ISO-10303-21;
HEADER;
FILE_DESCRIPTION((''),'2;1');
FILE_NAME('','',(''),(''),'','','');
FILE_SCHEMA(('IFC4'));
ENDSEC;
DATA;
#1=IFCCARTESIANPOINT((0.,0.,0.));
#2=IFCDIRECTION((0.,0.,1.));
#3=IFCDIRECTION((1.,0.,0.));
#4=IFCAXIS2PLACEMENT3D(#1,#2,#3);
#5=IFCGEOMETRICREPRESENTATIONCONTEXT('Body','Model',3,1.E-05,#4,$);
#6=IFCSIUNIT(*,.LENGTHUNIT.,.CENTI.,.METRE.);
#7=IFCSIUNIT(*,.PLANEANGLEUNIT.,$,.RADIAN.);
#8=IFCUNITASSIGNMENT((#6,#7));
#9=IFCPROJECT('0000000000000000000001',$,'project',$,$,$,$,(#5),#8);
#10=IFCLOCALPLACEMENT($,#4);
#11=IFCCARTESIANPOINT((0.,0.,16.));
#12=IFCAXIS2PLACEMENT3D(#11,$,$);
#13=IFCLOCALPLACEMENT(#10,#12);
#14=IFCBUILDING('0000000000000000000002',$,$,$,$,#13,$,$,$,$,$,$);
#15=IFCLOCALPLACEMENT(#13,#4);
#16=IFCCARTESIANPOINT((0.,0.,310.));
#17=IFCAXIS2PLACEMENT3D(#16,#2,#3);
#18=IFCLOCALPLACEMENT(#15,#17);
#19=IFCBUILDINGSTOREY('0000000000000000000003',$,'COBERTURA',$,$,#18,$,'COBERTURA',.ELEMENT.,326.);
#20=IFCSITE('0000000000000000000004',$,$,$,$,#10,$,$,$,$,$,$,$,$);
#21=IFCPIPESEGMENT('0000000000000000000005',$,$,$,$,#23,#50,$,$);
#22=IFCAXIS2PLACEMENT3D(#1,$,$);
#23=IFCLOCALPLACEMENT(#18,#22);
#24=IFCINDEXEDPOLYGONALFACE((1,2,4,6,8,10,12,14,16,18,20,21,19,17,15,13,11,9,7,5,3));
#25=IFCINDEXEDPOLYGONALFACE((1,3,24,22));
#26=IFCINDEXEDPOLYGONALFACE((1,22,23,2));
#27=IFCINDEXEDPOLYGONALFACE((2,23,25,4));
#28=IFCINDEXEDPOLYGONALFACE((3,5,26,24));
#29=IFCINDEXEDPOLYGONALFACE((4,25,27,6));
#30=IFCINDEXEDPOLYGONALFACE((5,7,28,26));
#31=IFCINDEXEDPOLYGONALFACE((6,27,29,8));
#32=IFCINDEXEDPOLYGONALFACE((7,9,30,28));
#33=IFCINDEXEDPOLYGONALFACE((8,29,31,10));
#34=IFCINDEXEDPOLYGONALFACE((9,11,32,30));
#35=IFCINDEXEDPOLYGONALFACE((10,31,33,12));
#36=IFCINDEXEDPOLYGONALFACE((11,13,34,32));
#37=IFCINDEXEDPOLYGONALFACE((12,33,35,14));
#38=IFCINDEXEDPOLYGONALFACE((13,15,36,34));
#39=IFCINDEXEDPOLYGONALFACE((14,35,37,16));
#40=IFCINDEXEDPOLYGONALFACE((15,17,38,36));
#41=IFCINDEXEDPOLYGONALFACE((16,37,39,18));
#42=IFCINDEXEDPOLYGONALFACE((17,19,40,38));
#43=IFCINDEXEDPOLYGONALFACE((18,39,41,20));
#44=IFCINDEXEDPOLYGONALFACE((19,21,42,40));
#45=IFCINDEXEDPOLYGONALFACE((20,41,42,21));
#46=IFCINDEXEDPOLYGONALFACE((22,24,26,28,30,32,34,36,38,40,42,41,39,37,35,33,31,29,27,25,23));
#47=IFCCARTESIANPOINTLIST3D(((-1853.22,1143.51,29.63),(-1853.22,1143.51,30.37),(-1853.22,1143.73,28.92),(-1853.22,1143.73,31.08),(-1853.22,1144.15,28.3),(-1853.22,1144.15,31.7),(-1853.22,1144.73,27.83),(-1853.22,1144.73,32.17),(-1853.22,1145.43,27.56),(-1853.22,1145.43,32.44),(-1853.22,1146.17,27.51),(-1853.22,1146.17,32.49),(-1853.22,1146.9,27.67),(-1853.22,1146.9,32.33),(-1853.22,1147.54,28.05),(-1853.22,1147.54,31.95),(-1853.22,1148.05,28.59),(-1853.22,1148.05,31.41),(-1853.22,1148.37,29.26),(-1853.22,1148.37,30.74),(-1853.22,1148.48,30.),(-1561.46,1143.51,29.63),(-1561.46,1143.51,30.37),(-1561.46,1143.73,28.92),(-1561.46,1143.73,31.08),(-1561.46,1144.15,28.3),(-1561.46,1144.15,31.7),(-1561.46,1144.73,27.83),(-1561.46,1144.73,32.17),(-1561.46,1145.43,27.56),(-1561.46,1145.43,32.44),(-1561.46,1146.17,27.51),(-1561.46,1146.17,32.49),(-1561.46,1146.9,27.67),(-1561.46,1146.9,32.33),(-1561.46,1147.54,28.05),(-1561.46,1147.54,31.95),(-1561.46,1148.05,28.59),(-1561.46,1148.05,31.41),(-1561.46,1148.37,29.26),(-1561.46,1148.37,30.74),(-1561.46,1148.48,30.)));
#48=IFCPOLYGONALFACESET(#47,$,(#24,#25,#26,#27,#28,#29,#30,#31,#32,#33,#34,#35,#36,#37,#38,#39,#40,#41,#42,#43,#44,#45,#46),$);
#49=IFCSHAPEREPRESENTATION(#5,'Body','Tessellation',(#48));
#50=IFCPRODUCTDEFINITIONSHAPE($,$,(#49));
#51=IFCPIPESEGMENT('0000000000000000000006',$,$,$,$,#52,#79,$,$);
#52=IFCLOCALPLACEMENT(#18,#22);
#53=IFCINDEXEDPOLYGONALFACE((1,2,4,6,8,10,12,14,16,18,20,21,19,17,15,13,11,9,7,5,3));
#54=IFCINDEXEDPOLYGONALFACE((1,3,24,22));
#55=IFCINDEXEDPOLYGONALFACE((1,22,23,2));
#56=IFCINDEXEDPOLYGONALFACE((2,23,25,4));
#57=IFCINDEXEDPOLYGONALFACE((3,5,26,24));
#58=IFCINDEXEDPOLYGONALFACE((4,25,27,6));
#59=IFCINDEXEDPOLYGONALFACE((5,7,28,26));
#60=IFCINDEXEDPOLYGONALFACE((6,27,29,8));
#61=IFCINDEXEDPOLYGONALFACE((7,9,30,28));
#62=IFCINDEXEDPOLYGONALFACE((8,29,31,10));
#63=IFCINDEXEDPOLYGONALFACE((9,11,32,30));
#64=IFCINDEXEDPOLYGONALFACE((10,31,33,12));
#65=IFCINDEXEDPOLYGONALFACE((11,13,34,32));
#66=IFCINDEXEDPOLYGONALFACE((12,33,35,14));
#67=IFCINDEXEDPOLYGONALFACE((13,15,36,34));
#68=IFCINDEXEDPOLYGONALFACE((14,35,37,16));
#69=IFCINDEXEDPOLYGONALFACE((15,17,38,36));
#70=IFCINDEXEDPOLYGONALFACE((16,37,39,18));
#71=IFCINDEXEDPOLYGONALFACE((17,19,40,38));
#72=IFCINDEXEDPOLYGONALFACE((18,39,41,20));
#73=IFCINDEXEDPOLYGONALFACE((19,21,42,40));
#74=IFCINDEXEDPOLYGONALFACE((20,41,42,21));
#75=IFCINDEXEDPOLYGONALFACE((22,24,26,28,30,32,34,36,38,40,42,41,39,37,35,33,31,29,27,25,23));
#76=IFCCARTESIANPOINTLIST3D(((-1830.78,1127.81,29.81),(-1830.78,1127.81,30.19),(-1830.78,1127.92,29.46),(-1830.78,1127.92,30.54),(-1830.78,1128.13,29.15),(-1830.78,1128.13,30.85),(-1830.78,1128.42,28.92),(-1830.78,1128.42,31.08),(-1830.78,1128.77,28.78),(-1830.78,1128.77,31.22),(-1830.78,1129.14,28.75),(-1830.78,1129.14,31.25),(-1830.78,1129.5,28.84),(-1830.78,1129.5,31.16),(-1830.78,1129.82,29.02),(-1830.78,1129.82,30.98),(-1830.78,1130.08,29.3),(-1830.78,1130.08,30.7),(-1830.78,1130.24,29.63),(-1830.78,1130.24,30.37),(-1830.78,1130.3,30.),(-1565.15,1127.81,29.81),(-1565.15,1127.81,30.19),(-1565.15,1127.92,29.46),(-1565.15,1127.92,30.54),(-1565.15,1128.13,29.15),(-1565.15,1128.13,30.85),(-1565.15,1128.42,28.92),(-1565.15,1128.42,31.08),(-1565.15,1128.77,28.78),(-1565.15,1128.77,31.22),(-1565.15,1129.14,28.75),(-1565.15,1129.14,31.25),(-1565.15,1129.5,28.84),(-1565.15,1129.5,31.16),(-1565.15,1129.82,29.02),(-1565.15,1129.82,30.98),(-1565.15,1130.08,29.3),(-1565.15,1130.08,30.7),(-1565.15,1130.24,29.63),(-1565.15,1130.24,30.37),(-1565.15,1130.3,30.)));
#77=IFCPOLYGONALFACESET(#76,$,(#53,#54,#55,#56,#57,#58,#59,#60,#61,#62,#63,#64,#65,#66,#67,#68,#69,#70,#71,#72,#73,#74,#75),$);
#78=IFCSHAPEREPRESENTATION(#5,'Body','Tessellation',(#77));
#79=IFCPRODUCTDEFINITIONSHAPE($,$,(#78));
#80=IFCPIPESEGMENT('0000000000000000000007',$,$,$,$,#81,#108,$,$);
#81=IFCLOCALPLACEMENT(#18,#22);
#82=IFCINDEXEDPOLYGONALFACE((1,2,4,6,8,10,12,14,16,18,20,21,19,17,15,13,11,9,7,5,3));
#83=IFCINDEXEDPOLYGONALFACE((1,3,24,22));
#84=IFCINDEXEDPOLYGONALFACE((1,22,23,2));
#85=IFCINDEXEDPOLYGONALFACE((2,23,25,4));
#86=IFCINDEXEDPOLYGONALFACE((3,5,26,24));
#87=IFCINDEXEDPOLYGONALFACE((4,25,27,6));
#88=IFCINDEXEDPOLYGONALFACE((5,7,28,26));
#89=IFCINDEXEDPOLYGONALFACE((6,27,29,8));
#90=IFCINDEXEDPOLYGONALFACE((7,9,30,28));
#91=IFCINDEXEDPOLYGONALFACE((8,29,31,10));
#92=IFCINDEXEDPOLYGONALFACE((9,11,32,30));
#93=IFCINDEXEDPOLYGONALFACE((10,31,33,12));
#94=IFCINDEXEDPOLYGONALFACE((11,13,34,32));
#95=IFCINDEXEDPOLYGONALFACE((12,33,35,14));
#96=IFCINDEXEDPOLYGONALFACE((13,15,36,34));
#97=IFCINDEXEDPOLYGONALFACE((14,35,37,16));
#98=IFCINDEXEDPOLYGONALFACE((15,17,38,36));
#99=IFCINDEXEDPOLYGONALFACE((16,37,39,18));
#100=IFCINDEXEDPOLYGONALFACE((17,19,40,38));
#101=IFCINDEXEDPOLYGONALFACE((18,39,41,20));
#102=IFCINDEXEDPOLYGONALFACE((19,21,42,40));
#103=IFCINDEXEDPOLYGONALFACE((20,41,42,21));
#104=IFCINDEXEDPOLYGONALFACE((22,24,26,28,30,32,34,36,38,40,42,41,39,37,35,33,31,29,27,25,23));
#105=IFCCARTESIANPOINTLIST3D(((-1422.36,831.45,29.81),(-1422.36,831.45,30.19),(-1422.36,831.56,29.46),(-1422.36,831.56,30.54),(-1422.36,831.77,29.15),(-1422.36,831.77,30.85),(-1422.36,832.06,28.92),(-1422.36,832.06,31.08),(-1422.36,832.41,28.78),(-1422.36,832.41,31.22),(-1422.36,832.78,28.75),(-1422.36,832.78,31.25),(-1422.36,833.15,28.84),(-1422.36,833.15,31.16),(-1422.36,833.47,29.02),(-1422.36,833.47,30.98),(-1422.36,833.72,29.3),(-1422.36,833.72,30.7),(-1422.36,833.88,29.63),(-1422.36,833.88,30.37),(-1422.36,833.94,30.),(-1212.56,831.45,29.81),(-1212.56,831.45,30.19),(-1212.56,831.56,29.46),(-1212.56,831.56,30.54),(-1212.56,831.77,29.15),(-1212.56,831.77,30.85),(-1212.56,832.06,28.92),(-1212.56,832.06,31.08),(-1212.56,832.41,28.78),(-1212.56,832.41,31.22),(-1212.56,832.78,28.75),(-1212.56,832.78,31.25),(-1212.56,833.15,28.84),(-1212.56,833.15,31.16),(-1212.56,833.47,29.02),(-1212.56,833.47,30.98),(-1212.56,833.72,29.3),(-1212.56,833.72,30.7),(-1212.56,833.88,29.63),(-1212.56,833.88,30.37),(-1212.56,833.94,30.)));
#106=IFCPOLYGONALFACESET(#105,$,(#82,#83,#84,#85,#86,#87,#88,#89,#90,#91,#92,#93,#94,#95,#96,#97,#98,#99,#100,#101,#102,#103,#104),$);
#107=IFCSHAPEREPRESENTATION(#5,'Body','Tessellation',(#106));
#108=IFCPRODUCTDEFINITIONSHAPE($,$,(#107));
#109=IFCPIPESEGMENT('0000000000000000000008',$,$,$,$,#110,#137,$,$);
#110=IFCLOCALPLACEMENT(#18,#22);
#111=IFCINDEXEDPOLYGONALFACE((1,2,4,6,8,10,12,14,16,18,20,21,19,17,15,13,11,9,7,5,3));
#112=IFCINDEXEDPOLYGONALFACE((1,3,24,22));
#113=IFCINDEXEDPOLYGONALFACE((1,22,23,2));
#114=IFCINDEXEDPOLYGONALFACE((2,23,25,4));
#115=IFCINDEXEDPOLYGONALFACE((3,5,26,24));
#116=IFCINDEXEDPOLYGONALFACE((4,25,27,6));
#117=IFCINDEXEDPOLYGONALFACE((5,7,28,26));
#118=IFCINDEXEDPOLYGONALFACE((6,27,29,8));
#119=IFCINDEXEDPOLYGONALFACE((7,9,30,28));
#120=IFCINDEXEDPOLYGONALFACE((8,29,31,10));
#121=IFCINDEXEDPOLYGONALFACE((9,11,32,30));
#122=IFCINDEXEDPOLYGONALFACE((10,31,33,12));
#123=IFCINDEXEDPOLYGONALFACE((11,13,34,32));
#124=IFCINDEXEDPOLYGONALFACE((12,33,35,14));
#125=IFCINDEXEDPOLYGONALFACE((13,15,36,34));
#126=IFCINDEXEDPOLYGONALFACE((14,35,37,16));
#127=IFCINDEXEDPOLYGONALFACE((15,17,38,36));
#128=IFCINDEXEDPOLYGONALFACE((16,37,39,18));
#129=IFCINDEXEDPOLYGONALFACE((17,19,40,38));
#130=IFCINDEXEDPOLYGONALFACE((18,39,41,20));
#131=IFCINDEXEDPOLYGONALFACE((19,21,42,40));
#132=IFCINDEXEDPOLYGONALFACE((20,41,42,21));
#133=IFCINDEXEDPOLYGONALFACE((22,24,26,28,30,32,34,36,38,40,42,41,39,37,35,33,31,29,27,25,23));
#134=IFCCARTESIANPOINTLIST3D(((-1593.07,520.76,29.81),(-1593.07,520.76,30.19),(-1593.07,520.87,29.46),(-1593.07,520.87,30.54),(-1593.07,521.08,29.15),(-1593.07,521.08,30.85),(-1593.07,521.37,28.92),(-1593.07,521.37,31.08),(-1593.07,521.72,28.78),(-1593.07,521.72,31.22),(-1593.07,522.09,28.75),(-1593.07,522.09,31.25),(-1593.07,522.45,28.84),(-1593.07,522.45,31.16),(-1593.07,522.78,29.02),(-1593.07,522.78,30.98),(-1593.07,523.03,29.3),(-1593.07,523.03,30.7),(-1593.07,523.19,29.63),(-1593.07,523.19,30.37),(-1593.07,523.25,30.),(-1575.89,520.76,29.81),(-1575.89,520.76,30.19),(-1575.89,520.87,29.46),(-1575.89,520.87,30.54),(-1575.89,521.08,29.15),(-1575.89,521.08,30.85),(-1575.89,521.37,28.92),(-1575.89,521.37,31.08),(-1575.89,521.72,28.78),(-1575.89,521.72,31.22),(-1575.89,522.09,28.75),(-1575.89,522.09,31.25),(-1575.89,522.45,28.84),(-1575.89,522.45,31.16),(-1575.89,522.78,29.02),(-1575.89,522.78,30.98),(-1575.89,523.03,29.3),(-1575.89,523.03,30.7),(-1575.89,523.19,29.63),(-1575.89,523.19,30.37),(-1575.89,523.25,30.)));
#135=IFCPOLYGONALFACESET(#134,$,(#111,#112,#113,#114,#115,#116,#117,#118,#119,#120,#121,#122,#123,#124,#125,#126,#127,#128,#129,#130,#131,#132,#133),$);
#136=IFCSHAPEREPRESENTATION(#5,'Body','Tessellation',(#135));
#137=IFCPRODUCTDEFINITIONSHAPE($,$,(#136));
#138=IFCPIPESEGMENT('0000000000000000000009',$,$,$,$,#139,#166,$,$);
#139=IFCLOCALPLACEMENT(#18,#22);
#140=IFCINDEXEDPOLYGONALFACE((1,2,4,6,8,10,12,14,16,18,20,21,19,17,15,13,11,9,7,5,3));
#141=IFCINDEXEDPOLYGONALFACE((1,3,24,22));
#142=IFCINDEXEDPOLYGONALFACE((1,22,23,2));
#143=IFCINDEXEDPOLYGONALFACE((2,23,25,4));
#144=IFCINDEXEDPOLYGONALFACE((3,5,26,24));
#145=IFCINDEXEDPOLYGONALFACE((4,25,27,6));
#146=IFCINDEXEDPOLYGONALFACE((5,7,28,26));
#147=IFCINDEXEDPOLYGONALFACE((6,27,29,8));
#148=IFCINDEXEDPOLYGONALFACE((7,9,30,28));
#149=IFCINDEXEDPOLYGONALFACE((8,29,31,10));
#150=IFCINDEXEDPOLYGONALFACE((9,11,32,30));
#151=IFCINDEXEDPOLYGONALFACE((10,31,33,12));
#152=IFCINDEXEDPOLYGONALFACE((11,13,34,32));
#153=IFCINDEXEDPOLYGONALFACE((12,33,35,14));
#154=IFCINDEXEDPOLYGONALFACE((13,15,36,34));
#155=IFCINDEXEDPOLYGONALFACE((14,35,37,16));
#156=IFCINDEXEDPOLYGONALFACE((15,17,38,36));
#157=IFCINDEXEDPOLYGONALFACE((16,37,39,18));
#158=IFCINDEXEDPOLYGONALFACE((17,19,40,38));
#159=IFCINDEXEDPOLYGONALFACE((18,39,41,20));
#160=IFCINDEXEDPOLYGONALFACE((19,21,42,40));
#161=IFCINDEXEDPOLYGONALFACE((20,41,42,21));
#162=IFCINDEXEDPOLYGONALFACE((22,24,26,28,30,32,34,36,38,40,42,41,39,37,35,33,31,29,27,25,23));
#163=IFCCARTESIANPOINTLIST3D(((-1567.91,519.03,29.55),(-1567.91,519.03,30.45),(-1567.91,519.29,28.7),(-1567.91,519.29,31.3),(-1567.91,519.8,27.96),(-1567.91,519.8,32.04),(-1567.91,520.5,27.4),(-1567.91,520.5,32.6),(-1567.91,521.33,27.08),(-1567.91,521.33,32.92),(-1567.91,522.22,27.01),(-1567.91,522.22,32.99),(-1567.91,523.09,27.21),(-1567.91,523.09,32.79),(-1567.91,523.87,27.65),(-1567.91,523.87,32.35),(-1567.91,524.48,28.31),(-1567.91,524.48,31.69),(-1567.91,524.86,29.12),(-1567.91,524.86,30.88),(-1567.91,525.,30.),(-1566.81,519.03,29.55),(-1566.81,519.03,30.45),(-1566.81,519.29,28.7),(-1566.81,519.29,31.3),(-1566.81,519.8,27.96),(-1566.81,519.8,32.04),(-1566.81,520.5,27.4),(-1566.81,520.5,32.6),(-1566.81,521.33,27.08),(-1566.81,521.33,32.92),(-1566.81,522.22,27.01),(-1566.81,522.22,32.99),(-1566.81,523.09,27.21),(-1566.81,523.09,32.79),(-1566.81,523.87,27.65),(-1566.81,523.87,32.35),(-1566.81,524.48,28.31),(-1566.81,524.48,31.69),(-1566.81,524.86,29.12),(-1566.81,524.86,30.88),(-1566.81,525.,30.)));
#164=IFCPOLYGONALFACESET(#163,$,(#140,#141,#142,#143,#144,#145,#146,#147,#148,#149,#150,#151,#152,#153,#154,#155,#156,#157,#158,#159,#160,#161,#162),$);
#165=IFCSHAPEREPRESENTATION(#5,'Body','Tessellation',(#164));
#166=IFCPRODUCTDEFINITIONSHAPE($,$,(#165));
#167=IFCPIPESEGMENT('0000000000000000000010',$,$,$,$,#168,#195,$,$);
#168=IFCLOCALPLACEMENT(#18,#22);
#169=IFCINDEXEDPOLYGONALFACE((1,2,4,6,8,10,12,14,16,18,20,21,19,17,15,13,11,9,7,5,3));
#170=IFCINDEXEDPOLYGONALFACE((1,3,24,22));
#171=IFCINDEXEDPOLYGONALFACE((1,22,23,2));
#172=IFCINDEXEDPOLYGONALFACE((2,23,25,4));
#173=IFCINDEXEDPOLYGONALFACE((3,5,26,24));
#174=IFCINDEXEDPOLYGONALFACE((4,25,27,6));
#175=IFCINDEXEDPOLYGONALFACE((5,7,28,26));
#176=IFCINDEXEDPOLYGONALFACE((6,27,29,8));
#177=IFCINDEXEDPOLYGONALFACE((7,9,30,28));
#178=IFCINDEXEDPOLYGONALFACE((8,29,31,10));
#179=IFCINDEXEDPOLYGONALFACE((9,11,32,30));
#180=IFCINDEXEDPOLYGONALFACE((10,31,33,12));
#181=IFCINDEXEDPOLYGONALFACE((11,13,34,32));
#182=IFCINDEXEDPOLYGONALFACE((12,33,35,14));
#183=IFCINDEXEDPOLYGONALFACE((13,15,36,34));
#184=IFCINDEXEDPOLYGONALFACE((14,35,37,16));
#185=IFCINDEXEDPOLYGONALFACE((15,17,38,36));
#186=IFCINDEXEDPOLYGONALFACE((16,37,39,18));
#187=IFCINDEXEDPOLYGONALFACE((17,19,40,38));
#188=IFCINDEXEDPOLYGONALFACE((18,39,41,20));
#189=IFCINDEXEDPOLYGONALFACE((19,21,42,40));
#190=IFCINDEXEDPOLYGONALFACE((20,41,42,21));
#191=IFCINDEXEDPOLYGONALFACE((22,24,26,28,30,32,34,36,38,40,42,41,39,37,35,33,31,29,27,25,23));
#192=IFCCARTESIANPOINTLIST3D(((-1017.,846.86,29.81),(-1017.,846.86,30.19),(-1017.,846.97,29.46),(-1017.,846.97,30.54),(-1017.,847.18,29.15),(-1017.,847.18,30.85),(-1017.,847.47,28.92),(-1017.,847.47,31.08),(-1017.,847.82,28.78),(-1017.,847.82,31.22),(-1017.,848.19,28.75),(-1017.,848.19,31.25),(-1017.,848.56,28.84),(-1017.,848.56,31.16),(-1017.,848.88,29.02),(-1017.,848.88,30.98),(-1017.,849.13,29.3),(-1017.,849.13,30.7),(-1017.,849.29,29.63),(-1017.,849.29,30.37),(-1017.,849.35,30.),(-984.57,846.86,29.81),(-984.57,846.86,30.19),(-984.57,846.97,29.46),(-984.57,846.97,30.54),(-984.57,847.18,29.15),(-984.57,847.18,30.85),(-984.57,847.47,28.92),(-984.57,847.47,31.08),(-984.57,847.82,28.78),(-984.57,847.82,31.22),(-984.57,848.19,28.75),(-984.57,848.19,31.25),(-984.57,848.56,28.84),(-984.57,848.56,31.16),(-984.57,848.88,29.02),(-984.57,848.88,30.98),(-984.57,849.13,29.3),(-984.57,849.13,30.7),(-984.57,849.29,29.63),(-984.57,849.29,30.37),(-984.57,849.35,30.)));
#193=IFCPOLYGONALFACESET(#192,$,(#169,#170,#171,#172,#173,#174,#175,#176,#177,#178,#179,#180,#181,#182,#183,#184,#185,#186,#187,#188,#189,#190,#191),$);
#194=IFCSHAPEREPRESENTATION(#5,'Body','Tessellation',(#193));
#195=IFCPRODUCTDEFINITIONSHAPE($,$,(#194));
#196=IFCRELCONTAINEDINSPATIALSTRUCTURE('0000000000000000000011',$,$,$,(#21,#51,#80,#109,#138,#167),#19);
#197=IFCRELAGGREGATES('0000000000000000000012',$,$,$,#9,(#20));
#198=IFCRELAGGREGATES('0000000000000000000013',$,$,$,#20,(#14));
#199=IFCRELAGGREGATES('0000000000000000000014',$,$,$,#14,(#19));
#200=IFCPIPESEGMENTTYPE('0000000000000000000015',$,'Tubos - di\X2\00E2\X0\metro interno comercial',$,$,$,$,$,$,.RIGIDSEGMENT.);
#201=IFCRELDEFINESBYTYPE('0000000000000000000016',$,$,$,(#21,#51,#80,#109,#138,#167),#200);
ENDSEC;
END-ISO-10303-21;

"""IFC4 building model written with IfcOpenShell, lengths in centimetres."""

from ifc_helpers import new_model, si_unit, frame, origin_with_axes, origin_2d_with_axis, place, context, project, spatial, circle, extrude, type_object, element, save


model = new_model("IFC4")

# Units and contexts
model_context = context("Model", 3, precision=1e-05, world=origin_with_axes(), identifier="Body")
ifc_project = project(units=[si_unit("LENGTHUNIT", "METRE", prefix="CENTI"), si_unit("PLANEANGLEUNIT", "RADIAN")], contexts=[model_context])

# Site, building, storey
site_placement = place(None, origin_with_axes())
site = spatial("IfcSite", under=ifc_project, at=site_placement)
building_placement = place(site_placement, frame((0.0, 0.0, 16.0)))
building = spatial("IfcBuilding", under=site, at=building_placement)
placement = place(building_placement, origin_with_axes())
storey_placement = place(placement, frame((0.0, 0.0, 310.0), z_axis=(0.0, 0.0, 1.0), x_axis=(1.0, 0.0, 0.0)))
storey = spatial("IfcBuildingStorey", under=building, at=storey_placement, Name="COBERTURA", LongName="COBERTURA", CompositionType="ELEMENT", Elevation=326.0)

# Pipe segments
pipe_segment_type = type_object("IfcPipeSegmentType", Name="Tubos - diâmetro interno comercial", PredefinedType="RIGIDSEGMENT")
pipe_segment_1_placement = place(storey_placement, frame((-1707.34, 1145.98, 32.5), z_axis=(0.0, 0.0, 1.0), x_axis=(1.0, 0.0, 0.0)))
element("IfcPipeSegment", 1, at=pipe_segment_1_placement, inside=storey, type_object=pipe_segment_type, context=model_context, shape_type="SolidModel", body=[
    extrude(circle(Radius=2.5, at=origin_2d_with_axis()), frame((145.88, 0.0, -2.5), z_axis=(-1.0, 0.0, 0.0), x_axis=(0.0, 1.0, 0.0)), (0.0, 0.0, 1.0), 291.76),
])
pipe_segment_2_placement = place(storey_placement, frame((-1697.96, 1129.05, 31.25), z_axis=(0.0, 0.0, 1.0), x_axis=(1.0, 0.0, 0.0)))
element("IfcPipeSegment", 2, at=pipe_segment_2_placement, inside=storey, type_object=pipe_segment_type, context=model_context, shape_type="SolidModel", body=[
    extrude(circle(Radius=1.25, at=origin_2d_with_axis()), frame((132.82, 0.0, -1.25), z_axis=(-1.0, 0.0, 0.0), x_axis=(0.0, 1.0, 0.0)), (0.0, 0.0, 1.0), 265.63),
])
pipe_segment_3_placement = place(storey_placement, frame((-1317.46, 832.69, 31.25), z_axis=(0.0, 0.0, 1.0), x_axis=(1.0, 0.0, 0.0)))
element("IfcPipeSegment", 3, at=pipe_segment_3_placement, inside=storey, type_object=pipe_segment_type, context=model_context, shape_type="SolidModel", body=[
    extrude(circle(Radius=1.25, at=origin_2d_with_axis()), frame((-104.9, 0.0, -1.25), z_axis=(1.0, 0.0, 0.0), x_axis=(0.0, 1.0, 0.0)), (0.0, 0.0, 1.0), 209.8),
])
pipe_segment_4_placement = place(storey_placement, frame((-1584.48, 522.0, 31.25), z_axis=(0.0, 0.0, 1.0), x_axis=(1.0, 0.0, 0.0)))
element("IfcPipeSegment", 4, at=pipe_segment_4_placement, inside=storey, type_object=pipe_segment_type, context=model_context, shape_type="SolidModel", body=[
    extrude(circle(Radius=1.25, at=origin_2d_with_axis()), frame((8.59, 0.0, -1.25), z_axis=(-1.0, 0.0, 0.0), x_axis=(0.0, 1.0, 0.0)), (0.0, 0.0, 1.0), 17.18),
])
pipe_segment_5_placement = place(storey_placement, frame((-1567.36, 522.0, 33.0), z_axis=(0.0, 0.0, 1.0), x_axis=(1.0, 0.0, 0.0)))
element("IfcPipeSegment", 5, at=pipe_segment_5_placement, inside=storey, type_object=pipe_segment_type, context=model_context, shape_type="SolidModel", body=[
    extrude(circle(Radius=3.0, at=origin_2d_with_axis()), frame((0.55, 0.0, -3.0), z_axis=(-1.0, 0.0, 0.0), x_axis=(0.0, 1.0, 0.0)), (0.0, 0.0, 1.0), 1.1),
])
pipe_segment_6_placement = place(storey_placement, frame((-1000.78, 848.1, 31.25), z_axis=(0.0, 0.0, 1.0), x_axis=(1.0, 0.0, 0.0)))
element("IfcPipeSegment", 6, at=pipe_segment_6_placement, inside=storey, type_object=pipe_segment_type, context=model_context, shape_type="SolidModel", body=[
    extrude(circle(Radius=1.25, at=origin_2d_with_axis()), frame((-16.21, 0.0, -1.25), z_axis=(1.0, 0.0, 0.0), x_axis=(0.0, 1.0, 0.0)), (0.0, 0.0, 1.0), 32.43),
])

save(model, "model.ifc")
